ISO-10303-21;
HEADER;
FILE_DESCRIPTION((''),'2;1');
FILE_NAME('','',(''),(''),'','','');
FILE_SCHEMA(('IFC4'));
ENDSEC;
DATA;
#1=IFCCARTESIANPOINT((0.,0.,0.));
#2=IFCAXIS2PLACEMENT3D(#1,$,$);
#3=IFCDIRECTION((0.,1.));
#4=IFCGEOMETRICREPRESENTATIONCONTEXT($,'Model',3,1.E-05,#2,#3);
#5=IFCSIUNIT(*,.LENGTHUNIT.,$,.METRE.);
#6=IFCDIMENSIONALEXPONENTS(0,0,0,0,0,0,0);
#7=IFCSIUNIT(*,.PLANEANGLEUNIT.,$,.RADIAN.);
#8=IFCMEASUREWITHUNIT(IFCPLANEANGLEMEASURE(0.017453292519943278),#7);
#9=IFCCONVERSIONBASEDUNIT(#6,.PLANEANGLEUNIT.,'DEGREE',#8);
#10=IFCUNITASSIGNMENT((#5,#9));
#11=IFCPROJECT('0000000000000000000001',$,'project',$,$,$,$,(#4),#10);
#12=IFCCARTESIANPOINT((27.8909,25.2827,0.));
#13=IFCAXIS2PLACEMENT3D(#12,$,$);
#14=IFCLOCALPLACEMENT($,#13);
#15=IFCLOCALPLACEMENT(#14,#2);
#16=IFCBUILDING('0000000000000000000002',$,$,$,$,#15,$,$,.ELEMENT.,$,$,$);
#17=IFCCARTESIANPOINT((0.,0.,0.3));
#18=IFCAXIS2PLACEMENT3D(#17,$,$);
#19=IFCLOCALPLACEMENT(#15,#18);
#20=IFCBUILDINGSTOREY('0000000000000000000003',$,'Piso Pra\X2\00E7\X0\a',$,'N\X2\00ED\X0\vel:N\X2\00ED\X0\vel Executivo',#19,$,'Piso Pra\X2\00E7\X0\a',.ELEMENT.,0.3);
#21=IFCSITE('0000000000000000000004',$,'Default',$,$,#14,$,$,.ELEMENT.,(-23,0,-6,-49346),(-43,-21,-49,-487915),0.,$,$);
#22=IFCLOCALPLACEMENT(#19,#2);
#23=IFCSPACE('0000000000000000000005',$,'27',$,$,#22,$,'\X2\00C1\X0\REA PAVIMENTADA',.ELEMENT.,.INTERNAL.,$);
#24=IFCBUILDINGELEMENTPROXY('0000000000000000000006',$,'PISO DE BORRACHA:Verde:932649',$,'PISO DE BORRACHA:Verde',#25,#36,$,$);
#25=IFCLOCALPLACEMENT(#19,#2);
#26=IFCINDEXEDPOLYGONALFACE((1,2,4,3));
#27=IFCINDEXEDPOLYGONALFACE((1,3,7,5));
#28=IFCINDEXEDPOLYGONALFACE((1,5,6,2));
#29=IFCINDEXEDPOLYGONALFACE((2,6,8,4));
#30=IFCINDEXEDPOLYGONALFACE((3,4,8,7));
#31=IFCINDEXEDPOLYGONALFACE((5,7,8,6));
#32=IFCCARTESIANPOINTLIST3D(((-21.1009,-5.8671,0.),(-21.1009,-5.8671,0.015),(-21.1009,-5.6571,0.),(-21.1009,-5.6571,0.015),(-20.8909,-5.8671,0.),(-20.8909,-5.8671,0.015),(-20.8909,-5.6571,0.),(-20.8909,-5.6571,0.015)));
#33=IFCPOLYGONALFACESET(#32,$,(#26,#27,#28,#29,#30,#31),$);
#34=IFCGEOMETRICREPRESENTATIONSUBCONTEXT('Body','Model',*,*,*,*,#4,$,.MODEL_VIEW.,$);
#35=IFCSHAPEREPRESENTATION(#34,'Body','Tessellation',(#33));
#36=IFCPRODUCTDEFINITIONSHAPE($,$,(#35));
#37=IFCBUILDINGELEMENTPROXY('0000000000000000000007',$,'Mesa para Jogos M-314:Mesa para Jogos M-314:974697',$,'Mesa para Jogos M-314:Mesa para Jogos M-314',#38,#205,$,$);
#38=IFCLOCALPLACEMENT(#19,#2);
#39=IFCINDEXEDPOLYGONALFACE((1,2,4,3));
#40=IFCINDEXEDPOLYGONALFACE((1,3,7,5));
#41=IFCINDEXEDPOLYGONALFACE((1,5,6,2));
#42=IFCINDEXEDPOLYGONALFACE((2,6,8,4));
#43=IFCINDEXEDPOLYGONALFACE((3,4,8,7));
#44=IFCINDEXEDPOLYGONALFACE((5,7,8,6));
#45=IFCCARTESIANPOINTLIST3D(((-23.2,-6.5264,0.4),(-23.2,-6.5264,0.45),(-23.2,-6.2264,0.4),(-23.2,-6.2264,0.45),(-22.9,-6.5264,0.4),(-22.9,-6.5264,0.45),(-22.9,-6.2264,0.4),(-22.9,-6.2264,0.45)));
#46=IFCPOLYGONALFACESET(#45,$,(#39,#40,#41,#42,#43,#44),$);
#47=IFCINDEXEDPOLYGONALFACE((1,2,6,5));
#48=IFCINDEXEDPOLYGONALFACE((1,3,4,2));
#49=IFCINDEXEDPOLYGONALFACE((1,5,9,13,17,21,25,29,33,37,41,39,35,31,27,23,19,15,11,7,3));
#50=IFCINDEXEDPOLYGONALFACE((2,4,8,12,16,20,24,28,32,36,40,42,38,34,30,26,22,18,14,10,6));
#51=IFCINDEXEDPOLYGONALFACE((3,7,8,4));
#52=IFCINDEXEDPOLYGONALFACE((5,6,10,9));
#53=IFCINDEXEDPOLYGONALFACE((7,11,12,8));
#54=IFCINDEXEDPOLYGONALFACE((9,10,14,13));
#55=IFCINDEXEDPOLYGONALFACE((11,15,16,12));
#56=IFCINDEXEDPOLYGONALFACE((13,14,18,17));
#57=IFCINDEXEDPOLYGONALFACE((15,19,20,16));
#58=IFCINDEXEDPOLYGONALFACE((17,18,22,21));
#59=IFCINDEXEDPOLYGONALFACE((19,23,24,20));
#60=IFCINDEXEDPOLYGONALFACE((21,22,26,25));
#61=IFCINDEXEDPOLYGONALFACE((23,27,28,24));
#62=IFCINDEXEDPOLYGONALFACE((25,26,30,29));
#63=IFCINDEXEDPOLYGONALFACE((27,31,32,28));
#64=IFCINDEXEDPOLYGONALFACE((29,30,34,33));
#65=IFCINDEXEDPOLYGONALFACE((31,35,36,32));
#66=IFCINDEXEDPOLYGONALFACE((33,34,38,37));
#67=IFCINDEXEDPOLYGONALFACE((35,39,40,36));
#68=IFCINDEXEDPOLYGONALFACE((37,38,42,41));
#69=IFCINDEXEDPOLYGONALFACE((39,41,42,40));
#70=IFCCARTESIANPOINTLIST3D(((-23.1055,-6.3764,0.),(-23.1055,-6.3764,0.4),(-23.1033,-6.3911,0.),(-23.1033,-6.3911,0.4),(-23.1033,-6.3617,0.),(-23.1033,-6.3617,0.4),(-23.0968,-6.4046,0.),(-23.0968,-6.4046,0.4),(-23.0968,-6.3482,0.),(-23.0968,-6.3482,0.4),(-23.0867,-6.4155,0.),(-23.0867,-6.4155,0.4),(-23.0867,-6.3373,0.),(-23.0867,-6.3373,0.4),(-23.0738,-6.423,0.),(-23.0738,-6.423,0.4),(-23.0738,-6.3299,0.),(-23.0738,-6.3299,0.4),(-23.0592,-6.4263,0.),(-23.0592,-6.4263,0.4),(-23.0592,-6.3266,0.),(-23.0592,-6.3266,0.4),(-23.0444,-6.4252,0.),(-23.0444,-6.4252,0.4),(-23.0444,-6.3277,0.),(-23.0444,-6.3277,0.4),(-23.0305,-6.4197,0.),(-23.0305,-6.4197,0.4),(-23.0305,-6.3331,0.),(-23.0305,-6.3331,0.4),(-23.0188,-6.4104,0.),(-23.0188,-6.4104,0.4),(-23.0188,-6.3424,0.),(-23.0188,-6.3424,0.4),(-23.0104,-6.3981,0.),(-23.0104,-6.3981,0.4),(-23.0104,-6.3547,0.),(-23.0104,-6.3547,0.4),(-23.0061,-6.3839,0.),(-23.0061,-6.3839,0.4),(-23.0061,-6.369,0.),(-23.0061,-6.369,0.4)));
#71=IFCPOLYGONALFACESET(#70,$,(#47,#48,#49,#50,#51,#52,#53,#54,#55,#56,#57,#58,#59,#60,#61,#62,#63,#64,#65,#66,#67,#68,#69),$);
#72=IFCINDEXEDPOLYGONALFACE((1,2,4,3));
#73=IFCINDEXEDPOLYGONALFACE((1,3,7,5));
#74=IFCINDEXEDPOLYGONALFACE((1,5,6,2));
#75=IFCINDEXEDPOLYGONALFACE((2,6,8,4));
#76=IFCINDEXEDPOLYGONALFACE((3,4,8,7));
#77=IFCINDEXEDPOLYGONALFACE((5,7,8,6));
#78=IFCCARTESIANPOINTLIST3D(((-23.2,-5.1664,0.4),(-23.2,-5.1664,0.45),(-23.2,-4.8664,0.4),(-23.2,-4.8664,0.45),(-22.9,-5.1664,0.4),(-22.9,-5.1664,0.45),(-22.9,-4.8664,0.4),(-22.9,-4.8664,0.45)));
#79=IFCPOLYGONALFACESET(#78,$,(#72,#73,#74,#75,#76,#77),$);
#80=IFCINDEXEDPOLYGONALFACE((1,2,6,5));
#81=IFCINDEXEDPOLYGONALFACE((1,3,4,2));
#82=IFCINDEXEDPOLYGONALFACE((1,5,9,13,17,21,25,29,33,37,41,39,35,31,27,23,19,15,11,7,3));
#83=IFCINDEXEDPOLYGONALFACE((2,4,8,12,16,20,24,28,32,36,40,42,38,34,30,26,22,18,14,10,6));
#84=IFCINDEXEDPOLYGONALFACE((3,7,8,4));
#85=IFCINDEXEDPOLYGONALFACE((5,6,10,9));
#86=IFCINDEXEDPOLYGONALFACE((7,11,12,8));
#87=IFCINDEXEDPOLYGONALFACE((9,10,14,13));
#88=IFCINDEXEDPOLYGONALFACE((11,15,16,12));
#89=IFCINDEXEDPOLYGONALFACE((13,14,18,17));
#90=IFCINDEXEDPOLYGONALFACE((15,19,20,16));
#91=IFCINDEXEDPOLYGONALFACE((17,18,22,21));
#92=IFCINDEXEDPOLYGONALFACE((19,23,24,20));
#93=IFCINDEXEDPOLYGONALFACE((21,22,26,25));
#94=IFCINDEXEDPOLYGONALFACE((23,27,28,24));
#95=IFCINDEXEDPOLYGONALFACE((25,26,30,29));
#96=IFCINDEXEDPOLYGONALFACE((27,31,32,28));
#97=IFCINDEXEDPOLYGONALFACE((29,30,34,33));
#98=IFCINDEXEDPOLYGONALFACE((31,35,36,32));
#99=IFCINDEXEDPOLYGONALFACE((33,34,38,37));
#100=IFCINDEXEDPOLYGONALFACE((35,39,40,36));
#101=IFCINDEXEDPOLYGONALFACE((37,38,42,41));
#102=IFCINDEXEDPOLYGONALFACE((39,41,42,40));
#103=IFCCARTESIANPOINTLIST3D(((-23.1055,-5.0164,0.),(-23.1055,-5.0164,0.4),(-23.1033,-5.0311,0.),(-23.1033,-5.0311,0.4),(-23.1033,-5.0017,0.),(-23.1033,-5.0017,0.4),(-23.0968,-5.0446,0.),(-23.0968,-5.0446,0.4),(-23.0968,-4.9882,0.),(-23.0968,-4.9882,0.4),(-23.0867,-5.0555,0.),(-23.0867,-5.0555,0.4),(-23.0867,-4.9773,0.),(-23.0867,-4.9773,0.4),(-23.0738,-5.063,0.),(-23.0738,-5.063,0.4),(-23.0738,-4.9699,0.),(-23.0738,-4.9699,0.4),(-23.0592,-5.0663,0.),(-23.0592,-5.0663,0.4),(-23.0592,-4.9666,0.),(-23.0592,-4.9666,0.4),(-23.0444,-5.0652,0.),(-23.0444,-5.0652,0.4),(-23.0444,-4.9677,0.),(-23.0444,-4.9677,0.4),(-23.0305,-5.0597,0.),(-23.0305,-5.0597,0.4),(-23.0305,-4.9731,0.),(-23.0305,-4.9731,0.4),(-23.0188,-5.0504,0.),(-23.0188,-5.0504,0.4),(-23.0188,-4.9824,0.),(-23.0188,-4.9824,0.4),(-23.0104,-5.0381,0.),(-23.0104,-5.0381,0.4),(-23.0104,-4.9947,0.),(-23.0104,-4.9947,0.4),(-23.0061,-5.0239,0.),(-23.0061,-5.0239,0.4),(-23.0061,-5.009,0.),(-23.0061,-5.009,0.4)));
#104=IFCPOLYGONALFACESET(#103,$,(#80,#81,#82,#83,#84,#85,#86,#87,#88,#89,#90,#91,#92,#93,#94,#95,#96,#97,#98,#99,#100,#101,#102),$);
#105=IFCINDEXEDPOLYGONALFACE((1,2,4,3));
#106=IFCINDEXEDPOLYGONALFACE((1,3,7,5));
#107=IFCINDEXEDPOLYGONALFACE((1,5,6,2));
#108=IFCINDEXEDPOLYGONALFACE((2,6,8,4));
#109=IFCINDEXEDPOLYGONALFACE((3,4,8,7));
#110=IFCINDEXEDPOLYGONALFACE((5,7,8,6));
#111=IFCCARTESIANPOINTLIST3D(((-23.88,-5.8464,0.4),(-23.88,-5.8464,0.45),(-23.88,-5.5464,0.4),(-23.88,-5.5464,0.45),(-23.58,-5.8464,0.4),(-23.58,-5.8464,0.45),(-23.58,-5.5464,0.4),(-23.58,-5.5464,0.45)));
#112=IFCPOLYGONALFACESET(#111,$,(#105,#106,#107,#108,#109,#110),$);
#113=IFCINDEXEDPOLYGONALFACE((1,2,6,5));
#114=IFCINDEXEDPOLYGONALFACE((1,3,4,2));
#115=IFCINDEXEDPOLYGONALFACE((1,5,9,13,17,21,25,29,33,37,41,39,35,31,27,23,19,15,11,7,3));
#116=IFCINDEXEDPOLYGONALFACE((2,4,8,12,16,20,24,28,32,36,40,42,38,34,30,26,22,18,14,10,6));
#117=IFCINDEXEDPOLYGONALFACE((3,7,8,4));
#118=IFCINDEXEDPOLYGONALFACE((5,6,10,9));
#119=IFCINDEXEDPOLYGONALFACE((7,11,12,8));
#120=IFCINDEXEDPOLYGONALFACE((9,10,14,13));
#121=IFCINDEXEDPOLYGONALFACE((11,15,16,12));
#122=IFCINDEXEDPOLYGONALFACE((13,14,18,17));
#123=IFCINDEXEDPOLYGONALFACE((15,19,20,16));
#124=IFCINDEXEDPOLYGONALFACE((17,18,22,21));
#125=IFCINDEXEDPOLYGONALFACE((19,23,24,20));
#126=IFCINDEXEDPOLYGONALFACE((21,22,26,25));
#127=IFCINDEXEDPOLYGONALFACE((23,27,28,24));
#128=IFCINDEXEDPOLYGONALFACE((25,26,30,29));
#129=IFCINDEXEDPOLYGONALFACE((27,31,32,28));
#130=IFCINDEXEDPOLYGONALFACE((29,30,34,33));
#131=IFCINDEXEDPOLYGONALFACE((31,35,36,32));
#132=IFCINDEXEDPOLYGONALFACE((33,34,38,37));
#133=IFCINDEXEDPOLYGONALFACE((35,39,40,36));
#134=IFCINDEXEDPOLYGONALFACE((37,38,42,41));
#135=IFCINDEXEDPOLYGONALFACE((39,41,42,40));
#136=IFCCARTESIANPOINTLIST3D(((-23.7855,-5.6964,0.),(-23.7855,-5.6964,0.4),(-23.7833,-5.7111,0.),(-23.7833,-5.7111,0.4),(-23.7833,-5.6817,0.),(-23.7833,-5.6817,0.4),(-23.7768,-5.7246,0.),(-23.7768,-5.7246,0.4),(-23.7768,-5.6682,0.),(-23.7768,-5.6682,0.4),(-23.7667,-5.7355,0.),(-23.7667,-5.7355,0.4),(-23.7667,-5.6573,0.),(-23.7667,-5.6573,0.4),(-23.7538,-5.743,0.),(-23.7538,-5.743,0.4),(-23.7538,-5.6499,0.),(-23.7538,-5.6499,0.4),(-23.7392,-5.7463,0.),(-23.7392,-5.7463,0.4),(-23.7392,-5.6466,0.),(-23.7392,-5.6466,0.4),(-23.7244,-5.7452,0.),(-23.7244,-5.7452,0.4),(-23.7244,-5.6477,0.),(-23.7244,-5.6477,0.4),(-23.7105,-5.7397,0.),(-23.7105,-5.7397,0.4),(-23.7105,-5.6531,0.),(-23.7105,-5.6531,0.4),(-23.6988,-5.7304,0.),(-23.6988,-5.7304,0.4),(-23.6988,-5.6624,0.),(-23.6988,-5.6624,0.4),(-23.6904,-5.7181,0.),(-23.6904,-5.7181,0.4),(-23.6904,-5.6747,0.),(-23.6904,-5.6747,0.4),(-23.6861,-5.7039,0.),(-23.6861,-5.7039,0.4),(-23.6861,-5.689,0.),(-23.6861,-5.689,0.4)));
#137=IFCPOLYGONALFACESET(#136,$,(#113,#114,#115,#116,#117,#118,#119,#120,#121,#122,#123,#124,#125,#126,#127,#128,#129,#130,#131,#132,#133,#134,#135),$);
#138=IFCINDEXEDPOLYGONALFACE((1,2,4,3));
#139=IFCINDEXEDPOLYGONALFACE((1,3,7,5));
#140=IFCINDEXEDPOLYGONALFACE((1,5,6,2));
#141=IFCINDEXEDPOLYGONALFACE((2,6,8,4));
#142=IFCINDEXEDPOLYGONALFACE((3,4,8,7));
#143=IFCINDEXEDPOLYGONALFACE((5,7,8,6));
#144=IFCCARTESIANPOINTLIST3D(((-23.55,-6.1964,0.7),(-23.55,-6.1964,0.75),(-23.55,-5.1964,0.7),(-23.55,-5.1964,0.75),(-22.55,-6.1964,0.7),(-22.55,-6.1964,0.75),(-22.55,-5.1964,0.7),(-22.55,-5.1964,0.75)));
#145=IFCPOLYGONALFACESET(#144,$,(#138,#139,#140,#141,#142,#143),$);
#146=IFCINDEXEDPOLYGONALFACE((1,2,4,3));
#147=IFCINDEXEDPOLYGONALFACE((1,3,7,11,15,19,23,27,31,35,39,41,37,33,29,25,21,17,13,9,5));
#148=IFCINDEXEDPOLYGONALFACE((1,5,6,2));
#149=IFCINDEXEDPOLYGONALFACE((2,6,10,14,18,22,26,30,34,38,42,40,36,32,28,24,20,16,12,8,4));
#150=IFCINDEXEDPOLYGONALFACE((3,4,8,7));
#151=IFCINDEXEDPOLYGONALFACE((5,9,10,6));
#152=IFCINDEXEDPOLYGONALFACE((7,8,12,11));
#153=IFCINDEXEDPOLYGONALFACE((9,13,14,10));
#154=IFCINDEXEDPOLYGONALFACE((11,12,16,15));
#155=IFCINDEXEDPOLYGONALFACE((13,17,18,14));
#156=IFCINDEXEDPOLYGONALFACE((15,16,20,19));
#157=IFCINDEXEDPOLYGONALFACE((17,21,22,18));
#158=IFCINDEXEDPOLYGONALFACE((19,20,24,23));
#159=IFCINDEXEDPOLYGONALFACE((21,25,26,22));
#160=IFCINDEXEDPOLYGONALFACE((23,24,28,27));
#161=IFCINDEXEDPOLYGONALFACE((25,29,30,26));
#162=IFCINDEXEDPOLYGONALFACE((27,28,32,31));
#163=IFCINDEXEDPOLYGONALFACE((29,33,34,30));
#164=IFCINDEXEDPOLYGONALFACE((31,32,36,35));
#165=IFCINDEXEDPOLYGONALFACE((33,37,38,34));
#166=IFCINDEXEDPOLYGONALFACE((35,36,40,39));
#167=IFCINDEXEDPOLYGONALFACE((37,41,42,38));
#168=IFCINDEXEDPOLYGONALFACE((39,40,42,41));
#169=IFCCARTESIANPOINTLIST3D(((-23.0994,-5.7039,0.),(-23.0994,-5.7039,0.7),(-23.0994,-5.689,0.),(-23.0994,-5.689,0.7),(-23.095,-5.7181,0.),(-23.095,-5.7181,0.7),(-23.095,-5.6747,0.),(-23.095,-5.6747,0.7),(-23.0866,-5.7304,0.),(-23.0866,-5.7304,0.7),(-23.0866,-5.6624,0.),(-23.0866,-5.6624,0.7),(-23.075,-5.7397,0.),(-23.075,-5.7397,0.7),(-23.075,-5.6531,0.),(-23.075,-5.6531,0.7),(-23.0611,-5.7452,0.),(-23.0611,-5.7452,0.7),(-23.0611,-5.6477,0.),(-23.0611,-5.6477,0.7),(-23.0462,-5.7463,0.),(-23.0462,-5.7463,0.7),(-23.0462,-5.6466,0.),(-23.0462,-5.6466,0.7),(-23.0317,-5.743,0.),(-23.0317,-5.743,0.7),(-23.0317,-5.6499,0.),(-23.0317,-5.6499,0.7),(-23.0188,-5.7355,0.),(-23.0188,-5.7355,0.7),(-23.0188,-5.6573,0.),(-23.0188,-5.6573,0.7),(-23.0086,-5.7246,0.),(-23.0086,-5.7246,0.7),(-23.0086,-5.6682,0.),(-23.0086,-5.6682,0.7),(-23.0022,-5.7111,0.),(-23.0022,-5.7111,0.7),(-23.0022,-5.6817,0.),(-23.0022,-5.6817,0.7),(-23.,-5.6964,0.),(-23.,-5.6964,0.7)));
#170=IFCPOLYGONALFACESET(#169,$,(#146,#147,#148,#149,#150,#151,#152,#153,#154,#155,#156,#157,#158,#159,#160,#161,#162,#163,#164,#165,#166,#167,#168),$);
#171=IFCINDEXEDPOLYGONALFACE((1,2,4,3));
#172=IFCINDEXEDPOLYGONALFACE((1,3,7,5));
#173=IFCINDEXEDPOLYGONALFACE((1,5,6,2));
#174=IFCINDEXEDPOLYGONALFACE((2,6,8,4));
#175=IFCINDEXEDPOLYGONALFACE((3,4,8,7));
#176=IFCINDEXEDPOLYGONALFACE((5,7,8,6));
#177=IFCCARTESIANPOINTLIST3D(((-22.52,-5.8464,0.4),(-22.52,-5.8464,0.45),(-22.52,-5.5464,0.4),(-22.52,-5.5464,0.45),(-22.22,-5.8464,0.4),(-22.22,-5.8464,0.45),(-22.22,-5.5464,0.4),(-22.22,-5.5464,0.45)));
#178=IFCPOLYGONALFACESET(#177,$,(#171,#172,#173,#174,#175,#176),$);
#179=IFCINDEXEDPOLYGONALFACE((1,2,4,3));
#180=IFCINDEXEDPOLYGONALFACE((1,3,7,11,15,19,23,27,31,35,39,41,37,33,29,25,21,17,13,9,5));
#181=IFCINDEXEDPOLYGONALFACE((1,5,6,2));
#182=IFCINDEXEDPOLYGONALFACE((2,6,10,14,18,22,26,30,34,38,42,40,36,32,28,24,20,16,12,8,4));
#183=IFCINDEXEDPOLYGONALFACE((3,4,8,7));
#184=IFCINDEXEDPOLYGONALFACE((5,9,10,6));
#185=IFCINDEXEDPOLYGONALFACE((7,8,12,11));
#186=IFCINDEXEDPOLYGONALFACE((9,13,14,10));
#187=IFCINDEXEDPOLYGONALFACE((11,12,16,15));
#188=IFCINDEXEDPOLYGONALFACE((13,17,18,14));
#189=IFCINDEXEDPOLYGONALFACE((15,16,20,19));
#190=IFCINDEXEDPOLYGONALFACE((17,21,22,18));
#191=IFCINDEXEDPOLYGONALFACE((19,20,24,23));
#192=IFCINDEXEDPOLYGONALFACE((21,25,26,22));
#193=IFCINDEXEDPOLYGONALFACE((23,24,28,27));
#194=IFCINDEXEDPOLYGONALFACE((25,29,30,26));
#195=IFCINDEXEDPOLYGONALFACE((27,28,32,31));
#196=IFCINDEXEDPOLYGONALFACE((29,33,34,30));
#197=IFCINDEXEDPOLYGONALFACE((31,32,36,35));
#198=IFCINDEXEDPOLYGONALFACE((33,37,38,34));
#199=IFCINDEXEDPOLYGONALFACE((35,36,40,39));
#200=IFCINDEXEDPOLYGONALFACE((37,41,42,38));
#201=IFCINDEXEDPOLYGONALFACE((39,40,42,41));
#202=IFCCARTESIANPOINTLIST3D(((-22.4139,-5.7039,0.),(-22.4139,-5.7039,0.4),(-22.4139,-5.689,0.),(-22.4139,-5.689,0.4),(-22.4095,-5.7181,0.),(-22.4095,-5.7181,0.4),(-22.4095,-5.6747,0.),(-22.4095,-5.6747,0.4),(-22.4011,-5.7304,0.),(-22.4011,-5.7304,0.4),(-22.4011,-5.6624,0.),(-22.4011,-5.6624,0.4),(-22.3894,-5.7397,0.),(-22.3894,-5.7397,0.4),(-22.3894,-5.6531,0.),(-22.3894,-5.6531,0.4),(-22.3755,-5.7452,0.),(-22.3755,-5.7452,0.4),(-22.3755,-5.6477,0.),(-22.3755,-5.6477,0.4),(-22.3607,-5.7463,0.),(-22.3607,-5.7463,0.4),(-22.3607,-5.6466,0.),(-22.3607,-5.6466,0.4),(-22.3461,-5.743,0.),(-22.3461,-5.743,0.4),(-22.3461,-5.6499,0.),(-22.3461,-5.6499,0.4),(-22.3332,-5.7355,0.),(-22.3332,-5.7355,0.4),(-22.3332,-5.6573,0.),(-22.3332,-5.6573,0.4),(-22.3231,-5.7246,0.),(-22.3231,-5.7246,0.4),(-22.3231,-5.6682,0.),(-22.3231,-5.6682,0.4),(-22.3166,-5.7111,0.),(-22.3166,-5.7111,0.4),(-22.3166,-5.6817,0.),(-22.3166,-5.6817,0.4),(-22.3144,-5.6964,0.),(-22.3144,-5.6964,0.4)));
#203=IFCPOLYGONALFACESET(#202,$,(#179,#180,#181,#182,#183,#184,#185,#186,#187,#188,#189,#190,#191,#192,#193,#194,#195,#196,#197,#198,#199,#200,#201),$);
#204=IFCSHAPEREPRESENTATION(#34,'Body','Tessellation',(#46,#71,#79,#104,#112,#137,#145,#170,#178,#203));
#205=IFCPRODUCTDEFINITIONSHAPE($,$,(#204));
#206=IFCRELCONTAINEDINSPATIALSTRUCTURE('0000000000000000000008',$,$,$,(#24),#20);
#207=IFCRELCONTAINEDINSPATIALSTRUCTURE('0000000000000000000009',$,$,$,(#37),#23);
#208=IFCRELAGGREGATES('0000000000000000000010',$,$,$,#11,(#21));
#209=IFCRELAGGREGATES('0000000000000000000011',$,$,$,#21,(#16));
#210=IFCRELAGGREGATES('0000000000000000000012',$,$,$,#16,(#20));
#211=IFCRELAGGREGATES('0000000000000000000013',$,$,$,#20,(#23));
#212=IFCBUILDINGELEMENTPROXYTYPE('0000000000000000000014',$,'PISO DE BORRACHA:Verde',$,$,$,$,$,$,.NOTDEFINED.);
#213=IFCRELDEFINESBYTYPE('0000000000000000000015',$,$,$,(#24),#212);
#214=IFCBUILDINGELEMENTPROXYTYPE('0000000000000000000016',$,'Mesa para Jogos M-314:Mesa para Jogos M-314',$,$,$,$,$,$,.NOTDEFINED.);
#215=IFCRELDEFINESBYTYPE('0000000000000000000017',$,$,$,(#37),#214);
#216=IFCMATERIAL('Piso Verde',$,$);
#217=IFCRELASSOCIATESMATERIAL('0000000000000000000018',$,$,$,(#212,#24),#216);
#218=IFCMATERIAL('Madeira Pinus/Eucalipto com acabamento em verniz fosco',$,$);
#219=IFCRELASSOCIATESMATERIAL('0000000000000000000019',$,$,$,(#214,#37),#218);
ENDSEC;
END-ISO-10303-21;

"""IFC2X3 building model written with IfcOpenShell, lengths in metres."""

from ifc_helpers import new_model, entity, si_unit, converted_unit, direction, frame, frame_2d, origin, origin_2d_with_axis, place, context, subcontext, project, spatial, rectangle, circle, extrude, source, transform, mapped, material, type_object, type_shapes, element, save


model = new_model("IFC2X3")

# Units and contexts
model_context = context("Model", 3, precision=1e-05, world=origin(), true_north=direction((0.0, 1.0)))
body_context = subcontext(model_context, "Body", "Model", "MODEL_VIEW")
ifc_project = project(units=[si_unit("LENGTHUNIT", "METRE"), converted_unit("PLANEANGLEUNIT", "DEGREE", entity("IfcPlaneAngleMeasure", 0.017453292519943278), si_unit("PLANEANGLEUNIT", "RADIAN"), dimensions=[0, 0, 0, 0, 0, 0, 0])], contexts=[model_context])

# Site, building, storey
site_placement = place(None, frame((27.8909, 25.2827, 0.0)))
site = spatial("IfcSite", under=ifc_project, at=site_placement, Name="Default", CompositionType="ELEMENT", RefLatitude=(-23, 0, -6, -49346), RefLongitude=(-43, -21, -49, -487915), RefElevation=0.0)
building_placement = place(site_placement, origin())
building = spatial("IfcBuilding", under=site, at=building_placement, CompositionType="ELEMENT")
storey_placement = place(building_placement, frame((0.0, 0.0, 0.3)))
storey = spatial("IfcBuildingStorey", under=building, at=storey_placement, Name="Piso Praça", ObjectType="Nível:Nível Executivo", LongName="Piso Praça", CompositionType="ELEMENT", Elevation=0.3)

# Building element proxy
ifc_material_1 = material(Name="Madeira Pinus/Eucalipto com acabamento em verniz fosco")
ifc_material_2 = material(Name="Piso Verde")
building_element_proxy_type_1 = type_object("IfcBuildingElementProxyType", Name="PISO DE BORRACHA:Verde", PredefinedType="NOTDEFINED", material=ifc_material_2)
shared_shape_1 = source(origin(), body_context, "Body", "SweptSolid", [
    extrude(rectangle(XDim=0.21, YDim=0.21, at=origin_2d_with_axis()), frame((0.105, 0.105, 0.0), z_axis=(0.0, 0.0, 1.0), x_axis=(-1.0, 0.0, 0.0)), (0.0, 0.0, 1.0), 0.015),
])
type_shapes(building_element_proxy_type_1, [shared_shape_1])
proxy_1_placement = place(storey_placement, frame((-21.1009, -5.6571, 0.0), z_axis=(0.0, 0.0, 1.0), x_axis=(0.0, -1.0, 0.0)))
element("IfcBuildingElementProxy", 1, at=proxy_1_placement, inside=storey, type_object=building_element_proxy_type_1, material=ifc_material_2, Name="PISO DE BORRACHA:Verde:932649", ObjectType="PISO DE BORRACHA:Verde", context=body_context, shape_type="MappedRepresentation", body=[
    mapped(shared_shape_1, transform((0.0, 0.0, 0.0), scale=1.0)),
])

# Shared definitions
space_1_placement = place(storey_placement, origin())
space_1 = spatial("IfcSpace", under=storey, at=space_1_placement, Name="27", LongName="ÁREA PAVIMENTADA", CompositionType="ELEMENT", InteriorOrExteriorSpace="INTERNAL")

# Building element proxy
building_element_proxy_type_2 = type_object("IfcBuildingElementProxyType", Name="Mesa para Jogos M-314:Mesa para Jogos M-314", PredefinedType="NOTDEFINED", material=ifc_material_1)
shared_shape_2 = source(origin(), body_context, "Body", "SweptSolid", [
    extrude(rectangle(XDim=0.3, YDim=0.3, at=frame_2d((0.0, 0.0), x_axis=(1.0, 0.0))), frame((0.0, -0.68, 0.4)), (0.0, 0.0, 1.0), 0.05),
    extrude(circle(Radius=0.05, at=frame_2d((0.0, 0.0), x_axis=(1.0, 0.0))), frame((-0.0055, -0.68, 0.0), z_axis=(0.0, 0.0, 1.0), x_axis=(-1.0, 0.0, 0.0)), (0.0, 0.0, 1.0), 0.4),
    extrude(rectangle(XDim=0.3, YDim=0.3, at=frame_2d((0.0, 0.0), x_axis=(1.0, 0.0))), frame((0.0, 0.68, 0.4), z_axis=(0.0, 0.0, 1.0), x_axis=(0.0, -1.0, 0.0)), (0.0, 0.0, 1.0), 0.05),
    extrude(circle(Radius=0.05, at=frame_2d((0.0, 0.0), x_axis=(1.0, 0.0))), frame((-0.0055, 0.68, 0.0), z_axis=(0.0, 0.0, 1.0), x_axis=(-1.0, 0.0, 0.0)), (0.0, 0.0, 1.0), 0.4),
    extrude(rectangle(XDim=0.3, YDim=0.3, at=frame_2d((0.0, 0.0), x_axis=(1.0, 0.0))), frame((-0.68, 0.0, 0.4), z_axis=(0.0, 0.0, 1.0), x_axis=(0.0, -1.0, 0.0)), (0.0, 0.0, 1.0), 0.05),
    extrude(circle(Radius=0.05, at=frame_2d((0.0, 0.0), x_axis=(1.0, 0.0))), frame((-0.6855, 0.0, 0.0), z_axis=(0.0, 0.0, 1.0), x_axis=(-1.0, 0.0, 0.0)), (0.0, 0.0, 1.0), 0.4),
    extrude(rectangle(XDim=1.0, YDim=1.0, at=frame_2d((0.0, 0.0), x_axis=(1.0, 0.0))), frame((0.0, 0.0, 0.7), z_axis=(0.0, 0.0, 1.0), x_axis=(-1.0, 0.0, 0.0)), (0.0, 0.0, 1.0), 0.05),
    extrude(circle(Radius=0.05, at=frame_2d((0.0, 0.0), x_axis=(1.0, 0.0))), origin(), (0.0, 0.0, 1.0), 0.7),
    extrude(rectangle(XDim=0.3, YDim=0.3, at=frame_2d((0.0, 0.0), x_axis=(1.0, 0.0))), frame((0.68, 0.0, 0.4), z_axis=(0.0, 0.0, 1.0), x_axis=(-1.0, 0.0, 0.0)), (0.0, 0.0, 1.0), 0.05),
    extrude(circle(Radius=0.05, at=frame_2d((0.0, 0.0), x_axis=(1.0, 0.0))), frame((0.6855, 0.0, 0.0)), (0.0, 0.0, 1.0), 0.4),
])
type_shapes(building_element_proxy_type_2, [shared_shape_2])
proxy_2_placement = place(space_1_placement, frame((-23.05, -5.6964, 0.0)))
element("IfcBuildingElementProxy", 2, at=proxy_2_placement, inside=space_1, type_object=building_element_proxy_type_2, material=ifc_material_1, Name="Mesa para Jogos M-314:Mesa para Jogos M-314:974697", ObjectType="Mesa para Jogos M-314:Mesa para Jogos M-314", context=body_context, shape_type="MappedRepresentation", body=[
    mapped(shared_shape_2, transform((0.0, 0.0, 0.0), scale=1.0)),
])

save(model, "model.ifc")
